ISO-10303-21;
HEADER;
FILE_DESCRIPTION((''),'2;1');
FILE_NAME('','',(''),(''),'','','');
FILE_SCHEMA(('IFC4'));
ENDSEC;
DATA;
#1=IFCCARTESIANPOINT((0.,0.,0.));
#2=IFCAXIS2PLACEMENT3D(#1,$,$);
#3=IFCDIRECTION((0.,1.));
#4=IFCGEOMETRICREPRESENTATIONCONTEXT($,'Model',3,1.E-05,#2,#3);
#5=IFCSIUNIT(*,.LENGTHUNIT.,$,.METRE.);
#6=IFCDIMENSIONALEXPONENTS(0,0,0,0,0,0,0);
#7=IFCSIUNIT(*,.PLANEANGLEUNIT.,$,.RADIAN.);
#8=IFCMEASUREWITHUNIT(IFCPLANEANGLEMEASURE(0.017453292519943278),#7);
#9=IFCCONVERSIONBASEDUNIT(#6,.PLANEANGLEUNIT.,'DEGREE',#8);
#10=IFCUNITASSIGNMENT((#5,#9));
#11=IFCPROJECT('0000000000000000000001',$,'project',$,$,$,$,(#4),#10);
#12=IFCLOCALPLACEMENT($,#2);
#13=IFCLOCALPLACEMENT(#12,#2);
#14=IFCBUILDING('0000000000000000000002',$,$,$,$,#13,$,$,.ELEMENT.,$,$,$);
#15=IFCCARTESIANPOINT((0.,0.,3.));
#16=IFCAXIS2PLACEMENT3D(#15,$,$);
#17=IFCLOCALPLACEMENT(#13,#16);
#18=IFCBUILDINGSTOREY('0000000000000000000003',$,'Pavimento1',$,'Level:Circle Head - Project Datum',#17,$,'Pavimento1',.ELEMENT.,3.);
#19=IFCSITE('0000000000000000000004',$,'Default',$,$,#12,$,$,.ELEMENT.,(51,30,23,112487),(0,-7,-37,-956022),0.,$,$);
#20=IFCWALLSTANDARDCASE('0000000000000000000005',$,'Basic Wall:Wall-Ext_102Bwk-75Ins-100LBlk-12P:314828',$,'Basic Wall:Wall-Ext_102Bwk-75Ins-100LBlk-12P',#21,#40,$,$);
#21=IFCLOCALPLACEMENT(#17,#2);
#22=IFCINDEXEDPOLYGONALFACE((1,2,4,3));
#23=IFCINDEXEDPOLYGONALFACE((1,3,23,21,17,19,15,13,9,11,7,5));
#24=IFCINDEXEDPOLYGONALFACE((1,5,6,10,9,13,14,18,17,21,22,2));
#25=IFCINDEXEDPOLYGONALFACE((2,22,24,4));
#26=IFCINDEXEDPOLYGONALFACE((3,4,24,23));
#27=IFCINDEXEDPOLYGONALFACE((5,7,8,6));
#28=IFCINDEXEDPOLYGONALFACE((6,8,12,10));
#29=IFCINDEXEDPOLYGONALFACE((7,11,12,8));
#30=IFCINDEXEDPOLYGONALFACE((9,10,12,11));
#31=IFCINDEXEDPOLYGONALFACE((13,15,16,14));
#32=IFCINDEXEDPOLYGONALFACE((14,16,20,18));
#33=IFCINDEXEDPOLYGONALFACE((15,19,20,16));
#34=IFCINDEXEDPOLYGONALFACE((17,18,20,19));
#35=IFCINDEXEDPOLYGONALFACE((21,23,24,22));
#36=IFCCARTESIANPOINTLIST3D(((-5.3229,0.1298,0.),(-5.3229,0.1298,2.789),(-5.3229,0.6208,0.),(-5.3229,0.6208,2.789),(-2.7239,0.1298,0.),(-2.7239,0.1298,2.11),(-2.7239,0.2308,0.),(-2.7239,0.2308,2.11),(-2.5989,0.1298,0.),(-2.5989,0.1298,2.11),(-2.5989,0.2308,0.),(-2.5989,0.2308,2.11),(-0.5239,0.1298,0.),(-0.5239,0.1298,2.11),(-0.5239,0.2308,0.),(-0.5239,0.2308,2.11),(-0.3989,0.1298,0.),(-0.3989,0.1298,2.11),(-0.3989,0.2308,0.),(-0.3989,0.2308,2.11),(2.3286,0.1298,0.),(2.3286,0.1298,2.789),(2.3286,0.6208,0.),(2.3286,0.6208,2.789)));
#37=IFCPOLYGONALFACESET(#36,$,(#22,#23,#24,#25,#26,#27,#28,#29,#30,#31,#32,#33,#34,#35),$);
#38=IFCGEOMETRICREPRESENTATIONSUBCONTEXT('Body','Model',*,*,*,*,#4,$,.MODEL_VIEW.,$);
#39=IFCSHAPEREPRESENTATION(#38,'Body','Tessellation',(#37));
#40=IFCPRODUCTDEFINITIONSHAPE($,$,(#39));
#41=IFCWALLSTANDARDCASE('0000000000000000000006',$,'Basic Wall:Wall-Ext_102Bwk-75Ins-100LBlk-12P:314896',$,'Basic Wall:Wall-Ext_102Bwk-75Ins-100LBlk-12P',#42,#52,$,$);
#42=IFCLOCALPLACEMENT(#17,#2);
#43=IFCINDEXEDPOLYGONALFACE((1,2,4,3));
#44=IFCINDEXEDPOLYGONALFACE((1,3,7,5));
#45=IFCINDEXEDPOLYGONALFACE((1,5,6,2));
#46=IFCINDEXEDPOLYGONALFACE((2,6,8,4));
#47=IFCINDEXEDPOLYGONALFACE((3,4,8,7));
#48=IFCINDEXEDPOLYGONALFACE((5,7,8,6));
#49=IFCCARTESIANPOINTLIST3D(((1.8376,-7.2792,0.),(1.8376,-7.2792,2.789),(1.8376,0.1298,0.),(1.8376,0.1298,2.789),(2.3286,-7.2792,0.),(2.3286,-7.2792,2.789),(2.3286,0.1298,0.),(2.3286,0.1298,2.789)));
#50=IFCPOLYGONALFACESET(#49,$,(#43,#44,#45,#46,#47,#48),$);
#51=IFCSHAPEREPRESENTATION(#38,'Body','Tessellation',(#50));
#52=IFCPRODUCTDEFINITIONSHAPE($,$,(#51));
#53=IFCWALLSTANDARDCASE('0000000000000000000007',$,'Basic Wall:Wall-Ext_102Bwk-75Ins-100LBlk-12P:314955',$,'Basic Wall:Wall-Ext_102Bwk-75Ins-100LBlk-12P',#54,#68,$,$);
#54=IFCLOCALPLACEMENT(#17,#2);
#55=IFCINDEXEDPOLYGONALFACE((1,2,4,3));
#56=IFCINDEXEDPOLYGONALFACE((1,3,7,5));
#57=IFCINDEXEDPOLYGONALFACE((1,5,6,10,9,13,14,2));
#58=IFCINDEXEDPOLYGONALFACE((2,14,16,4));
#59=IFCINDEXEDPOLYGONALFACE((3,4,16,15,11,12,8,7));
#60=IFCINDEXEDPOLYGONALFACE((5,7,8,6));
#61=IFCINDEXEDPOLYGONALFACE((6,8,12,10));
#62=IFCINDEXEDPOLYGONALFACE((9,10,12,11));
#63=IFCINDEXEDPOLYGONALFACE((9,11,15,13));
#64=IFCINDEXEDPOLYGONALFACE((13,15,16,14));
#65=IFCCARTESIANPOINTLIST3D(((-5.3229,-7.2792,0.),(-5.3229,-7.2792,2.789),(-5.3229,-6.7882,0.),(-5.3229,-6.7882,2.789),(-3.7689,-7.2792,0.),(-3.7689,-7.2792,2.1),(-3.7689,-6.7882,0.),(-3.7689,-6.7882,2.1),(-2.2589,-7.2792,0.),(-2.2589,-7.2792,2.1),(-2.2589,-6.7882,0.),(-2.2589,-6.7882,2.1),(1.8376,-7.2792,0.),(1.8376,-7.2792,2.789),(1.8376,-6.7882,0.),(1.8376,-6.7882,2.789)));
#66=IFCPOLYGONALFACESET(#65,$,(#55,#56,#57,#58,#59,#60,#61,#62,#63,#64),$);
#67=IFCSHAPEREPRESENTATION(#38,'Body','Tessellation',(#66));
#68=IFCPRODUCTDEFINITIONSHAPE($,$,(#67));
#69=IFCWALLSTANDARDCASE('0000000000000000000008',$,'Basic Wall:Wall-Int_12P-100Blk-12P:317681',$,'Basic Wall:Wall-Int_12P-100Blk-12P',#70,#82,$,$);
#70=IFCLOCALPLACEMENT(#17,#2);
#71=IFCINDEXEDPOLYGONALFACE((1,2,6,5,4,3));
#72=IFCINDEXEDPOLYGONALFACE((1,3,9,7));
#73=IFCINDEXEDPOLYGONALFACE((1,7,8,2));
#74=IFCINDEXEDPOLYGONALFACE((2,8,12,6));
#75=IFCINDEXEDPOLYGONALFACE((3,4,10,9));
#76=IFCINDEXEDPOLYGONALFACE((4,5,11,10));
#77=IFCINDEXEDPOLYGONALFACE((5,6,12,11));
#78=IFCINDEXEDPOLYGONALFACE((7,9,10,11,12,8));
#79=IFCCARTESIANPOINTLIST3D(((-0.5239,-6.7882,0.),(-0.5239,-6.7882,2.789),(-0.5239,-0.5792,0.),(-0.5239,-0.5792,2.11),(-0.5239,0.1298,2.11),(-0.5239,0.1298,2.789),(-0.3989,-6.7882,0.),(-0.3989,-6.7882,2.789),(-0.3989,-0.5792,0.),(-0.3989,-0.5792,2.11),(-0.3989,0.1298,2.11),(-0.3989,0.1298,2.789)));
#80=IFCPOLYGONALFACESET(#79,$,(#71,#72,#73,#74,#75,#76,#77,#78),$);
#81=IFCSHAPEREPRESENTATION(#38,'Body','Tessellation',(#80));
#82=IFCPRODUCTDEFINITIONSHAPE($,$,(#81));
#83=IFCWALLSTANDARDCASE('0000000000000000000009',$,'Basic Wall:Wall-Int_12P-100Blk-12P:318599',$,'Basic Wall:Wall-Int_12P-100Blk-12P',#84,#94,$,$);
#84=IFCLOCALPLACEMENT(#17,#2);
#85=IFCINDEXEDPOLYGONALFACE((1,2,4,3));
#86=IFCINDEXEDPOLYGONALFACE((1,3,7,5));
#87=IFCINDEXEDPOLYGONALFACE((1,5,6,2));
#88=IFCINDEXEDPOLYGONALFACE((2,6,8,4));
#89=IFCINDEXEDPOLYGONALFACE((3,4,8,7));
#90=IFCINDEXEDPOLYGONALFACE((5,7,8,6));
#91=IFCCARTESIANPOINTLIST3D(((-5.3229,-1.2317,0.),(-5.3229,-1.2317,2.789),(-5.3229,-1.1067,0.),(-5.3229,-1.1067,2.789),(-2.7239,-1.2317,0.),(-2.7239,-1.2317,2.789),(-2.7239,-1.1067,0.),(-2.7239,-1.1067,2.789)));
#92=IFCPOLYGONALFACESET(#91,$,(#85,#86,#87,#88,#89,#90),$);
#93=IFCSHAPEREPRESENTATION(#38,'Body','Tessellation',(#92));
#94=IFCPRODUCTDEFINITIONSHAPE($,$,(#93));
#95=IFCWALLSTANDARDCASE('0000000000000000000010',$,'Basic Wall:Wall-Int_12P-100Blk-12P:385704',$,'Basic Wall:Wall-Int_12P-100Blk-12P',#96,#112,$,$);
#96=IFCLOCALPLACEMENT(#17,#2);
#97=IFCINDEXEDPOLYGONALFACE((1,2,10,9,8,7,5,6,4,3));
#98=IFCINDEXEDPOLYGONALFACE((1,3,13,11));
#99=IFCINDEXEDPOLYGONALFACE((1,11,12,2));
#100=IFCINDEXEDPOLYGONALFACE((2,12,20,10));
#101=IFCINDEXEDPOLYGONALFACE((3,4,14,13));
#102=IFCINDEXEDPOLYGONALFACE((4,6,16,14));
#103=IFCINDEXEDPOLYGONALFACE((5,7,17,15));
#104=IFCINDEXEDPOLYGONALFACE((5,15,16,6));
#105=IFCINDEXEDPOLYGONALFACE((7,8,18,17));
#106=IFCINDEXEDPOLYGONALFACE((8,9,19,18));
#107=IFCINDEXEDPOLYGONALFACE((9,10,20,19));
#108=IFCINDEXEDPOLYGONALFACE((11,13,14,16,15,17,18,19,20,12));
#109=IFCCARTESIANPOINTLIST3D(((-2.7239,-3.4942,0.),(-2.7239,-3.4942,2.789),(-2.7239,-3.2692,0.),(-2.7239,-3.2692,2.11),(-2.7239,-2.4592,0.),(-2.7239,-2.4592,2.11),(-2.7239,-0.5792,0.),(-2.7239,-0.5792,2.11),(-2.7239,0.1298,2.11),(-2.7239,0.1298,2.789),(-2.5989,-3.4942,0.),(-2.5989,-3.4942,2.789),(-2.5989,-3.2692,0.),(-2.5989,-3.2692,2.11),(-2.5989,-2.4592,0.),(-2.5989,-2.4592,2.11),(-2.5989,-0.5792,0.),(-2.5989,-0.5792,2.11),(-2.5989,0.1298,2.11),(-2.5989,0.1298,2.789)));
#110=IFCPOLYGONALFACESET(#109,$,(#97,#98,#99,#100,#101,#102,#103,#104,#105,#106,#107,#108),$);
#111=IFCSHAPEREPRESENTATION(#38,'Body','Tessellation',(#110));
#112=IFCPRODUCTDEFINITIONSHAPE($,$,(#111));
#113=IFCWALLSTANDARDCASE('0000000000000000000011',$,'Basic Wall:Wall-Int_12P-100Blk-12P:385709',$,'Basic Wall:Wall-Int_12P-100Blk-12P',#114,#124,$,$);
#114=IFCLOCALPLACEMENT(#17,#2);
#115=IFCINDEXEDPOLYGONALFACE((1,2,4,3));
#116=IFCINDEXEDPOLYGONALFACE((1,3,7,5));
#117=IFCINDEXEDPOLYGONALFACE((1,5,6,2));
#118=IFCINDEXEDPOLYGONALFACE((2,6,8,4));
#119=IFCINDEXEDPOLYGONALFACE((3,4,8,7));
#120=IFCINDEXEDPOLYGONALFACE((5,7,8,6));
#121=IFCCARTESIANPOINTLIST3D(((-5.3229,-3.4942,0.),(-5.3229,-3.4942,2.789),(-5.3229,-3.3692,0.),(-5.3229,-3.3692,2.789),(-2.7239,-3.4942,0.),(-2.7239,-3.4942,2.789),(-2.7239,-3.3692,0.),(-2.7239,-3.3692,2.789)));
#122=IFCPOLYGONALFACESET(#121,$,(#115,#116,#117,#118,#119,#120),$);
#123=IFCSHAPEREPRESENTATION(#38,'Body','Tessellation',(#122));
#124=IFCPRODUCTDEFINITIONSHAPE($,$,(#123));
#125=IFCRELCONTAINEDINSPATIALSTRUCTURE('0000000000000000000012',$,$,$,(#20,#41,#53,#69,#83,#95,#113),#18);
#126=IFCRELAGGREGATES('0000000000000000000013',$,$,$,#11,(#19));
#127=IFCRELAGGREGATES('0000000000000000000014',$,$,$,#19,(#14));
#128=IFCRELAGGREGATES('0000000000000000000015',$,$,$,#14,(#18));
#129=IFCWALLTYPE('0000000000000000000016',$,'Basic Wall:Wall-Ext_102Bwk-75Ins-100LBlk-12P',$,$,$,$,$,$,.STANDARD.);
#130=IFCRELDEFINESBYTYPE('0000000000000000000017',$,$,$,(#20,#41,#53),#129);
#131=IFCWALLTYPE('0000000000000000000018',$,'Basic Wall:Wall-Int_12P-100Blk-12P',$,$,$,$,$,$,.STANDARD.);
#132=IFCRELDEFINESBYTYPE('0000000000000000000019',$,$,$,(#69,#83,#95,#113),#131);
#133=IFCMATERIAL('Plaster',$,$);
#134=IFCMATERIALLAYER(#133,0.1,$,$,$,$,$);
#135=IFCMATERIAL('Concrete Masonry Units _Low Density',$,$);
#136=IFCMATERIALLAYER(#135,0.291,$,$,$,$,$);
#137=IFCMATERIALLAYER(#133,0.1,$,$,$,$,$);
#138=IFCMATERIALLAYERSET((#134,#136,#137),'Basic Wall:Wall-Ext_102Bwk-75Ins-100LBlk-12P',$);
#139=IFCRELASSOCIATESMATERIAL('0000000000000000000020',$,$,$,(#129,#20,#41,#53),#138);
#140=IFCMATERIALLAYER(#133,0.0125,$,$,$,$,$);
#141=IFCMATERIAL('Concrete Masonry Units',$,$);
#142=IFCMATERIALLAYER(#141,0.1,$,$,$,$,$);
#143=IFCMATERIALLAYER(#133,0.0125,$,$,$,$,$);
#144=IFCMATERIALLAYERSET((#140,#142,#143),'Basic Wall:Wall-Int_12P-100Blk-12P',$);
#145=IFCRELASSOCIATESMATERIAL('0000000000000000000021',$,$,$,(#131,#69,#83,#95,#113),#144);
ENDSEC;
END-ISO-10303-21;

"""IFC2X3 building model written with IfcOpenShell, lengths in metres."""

from ifc_helpers import new_model, entity, si_unit, converted_unit, direction, frame, frame_2d, origin, place, context, subcontext, project, spatial, polyline, rectangle, extrude, clip, bounded_halfspace, material, layer, layer_set, layer_usage, type_object, element, save


model = new_model("IFC2X3")

# Units and contexts
model_context = context("Model", 3, precision=1e-05, world=origin(), true_north=direction((0.0, 1.0)))
body_context = subcontext(model_context, "Body", "Model", "MODEL_VIEW")
ifc_project = project(units=[si_unit("LENGTHUNIT", "METRE"), converted_unit("PLANEANGLEUNIT", "DEGREE", entity("IfcPlaneAngleMeasure", 0.017453292519943278), si_unit("PLANEANGLEUNIT", "RADIAN"), dimensions=[0, 0, 0, 0, 0, 0, 0])], contexts=[model_context])

# Site, building, storey
site_placement = place(None, origin())
site = spatial("IfcSite", under=ifc_project, at=site_placement, Name="Default", CompositionType="ELEMENT", RefLatitude=(51, 30, 23, 112487), RefLongitude=(0, -7, -37, -956022), RefElevation=0.0)
building_placement = place(site_placement, origin())
building = spatial("IfcBuilding", under=site, at=building_placement, CompositionType="ELEMENT")
storey_placement = place(building_placement, frame((0.0, 0.0, 3.0)))
storey = spatial("IfcBuildingStorey", under=building, at=storey_placement, Name="Pavimento1", ObjectType="Level:Circle Head - Project Datum", LongName="Pavimento1", CompositionType="ELEMENT", Elevation=3.0)

# Wall, openings
ifc_material_1 = material(Name="Plaster")
ifc_layer_1 = layer(ifc_material_1, 0.1)
ifc_material_2 = material(Name="Concrete Masonry Units _Low Density")
ifc_layer_2 = layer(ifc_material_2, 0.291)
ifc_layer_3 = layer(ifc_material_1, 0.1)
ifc_layer_set_1 = layer_set([ifc_layer_1, ifc_layer_2, ifc_layer_3], Name="Basic Wall:Wall-Ext_102Bwk-75Ins-100LBlk-12P")
ifc_layer_usage_1 = layer_usage(ifc_layer_set_1, "AXIS2", "NEGATIVE", 0.2455)
wall_type_1 = type_object("IfcWallType", Name="Basic Wall:Wall-Ext_102Bwk-75Ins-100LBlk-12P", PredefinedType="STANDARD", material=ifc_layer_set_1)
wall_1_placement = place(storey_placement, frame((-5.3229, 0.3753, 0.0)))
wall_1 = element("IfcWallStandardCase", 1, at=wall_1_placement, inside=storey, type_object=wall_type_1, material=ifc_layer_usage_1, Name="Basic Wall:Wall-Ext_102Bwk-75Ins-100LBlk-12P:314828", ObjectType="Basic Wall:Wall-Ext_102Bwk-75Ins-100LBlk-12P", context=body_context, shape_type="Clipping", body=[
    clip(extrude(rectangle(XDim=7.6515, YDim=0.491, at=frame_2d((3.8258, 0.0), x_axis=(-1.0, 0.0))), origin(), (0.0, 0.0, 1.0), 2.789), bounded_halfspace(frame((0.0, -0.2455, 2.789), z_axis=(0.0, 0.0, -1.0), x_axis=(0.0, -1.0, 0.0)), True, frame((0.0, -0.2455, 2.789)), polyline([(0.0, 0.0), (2.599, 0.0), (2.724, 0.0), (4.799, 0.0), (4.924, 0.0), (7.1605, 0.0), (7.6515, 0.0), (7.6515, 0.491), (0.0, 0.491), (0.0, 0.0)]))),
])
opening_1_placement = place(wall_1_placement, origin())
element("IfcOpeningElement", 2, at=opening_1_placement, cuts=wall_1, ObjectType="Opening", context=body_context, shape_type="SweptSolid", body=[
    extrude(rectangle(XDim=2.11, YDim=0.125, at=frame_2d((0.0, 0.0), x_axis=(0.0, 1.0))), frame((2.6615, -0.9545, 1.055), z_axis=(0.0, 1.0, 0.0), x_axis=(-1.0, 0.0, 0.0)), (0.0, 0.0, 1.0), 0.81),
])
opening_2_placement = place(wall_1_placement, origin())
element("IfcOpeningElement", 3, at=opening_2_placement, cuts=wall_1, ObjectType="Opening", context=body_context, shape_type="SweptSolid", body=[
    extrude(rectangle(XDim=2.11, YDim=0.125, at=frame_2d((0.0, 0.0), x_axis=(0.0, 1.0))), frame((4.8615, -0.9545, 1.055), z_axis=(0.0, 1.0, 0.0), x_axis=(-1.0, 0.0, 0.0)), (0.0, 0.0, 1.0), 0.81),
])

# Wall
wall_2_placement = place(storey_placement, frame((2.0831, 0.1298, 0.0), z_axis=(0.0, 0.0, 1.0), x_axis=(0.0, -1.0, 0.0)))
element("IfcWallStandardCase", 4, at=wall_2_placement, inside=storey, type_object=wall_type_1, material=ifc_layer_usage_1, Name="Basic Wall:Wall-Ext_102Bwk-75Ins-100LBlk-12P:314896", ObjectType="Basic Wall:Wall-Ext_102Bwk-75Ins-100LBlk-12P", context=body_context, shape_type="Clipping", body=[
    clip(extrude(rectangle(XDim=7.409, YDim=0.491, at=frame_2d((3.7045, 0.0), x_axis=(-1.0, 0.0))), origin(), (0.0, 0.0, 1.0), 2.789), bounded_halfspace(frame((0.0, -0.2455, 2.789), z_axis=(0.0, 0.0, -1.0), x_axis=(1.0, 0.0, 0.0)), True, frame((0.0, -0.2455, 2.789)), polyline([(0.0, 0.0), (1.7625, 0.0), (6.0125, 0.0), (6.918, 0.0), (7.409, 0.0), (7.409, 0.491), (0.0, 0.491), (0.0, 0.0)]))),
])

# Walls, openings
wall_3_placement = place(storey_placement, frame((1.8376, -7.0337, 0.0), z_axis=(0.0, 0.0, 1.0), x_axis=(-1.0, 0.0, 0.0)))
wall_3 = element("IfcWallStandardCase", 5, at=wall_3_placement, inside=storey, type_object=wall_type_1, material=ifc_layer_usage_1, Name="Basic Wall:Wall-Ext_102Bwk-75Ins-100LBlk-12P:314955", ObjectType="Basic Wall:Wall-Ext_102Bwk-75Ins-100LBlk-12P", context=body_context, shape_type="Clipping", body=[
    clip(extrude(rectangle(XDim=7.1605, YDim=0.491, at=frame_2d((3.5803, 0.0), x_axis=(-1.0, 0.0))), origin(), (0.0, 0.0, 1.0), 2.789), bounded_halfspace(frame((0.0, 0.2455, 2.789), z_axis=(0.0, 0.0, -1.0), x_axis=(0.0, 1.0, 0.0)), True, frame((0.0, 0.2455, 2.789)), polyline([(0.0, 0.0), (0.0, -0.491), (2.2365, -0.491), (2.3615, -0.491), (7.1605, -0.491), (7.1605, 0.0), (6.3515, 0.0), (3.3515, 0.0), (0.0, 0.0)]))),
])
opening_3_placement = place(wall_3_placement, frame((1.8376, -7.0337, 0.0), z_axis=(0.0, 0.0, 1.0), x_axis=(-1.0, 0.0, 0.0)))
element("IfcOpeningElement", 6, at=opening_3_placement, cuts=wall_3, ObjectType="Opening", context=body_context, shape_type="SweptSolid", body=[
    extrude(rectangle(XDim=2.1, YDim=1.51, at=frame_2d((0.0, 0.0), x_axis=(0.0, 1.0))), frame((-3.0139, -6.4882, 1.05), z_axis=(0.0, -1.0, 0.0), x_axis=(-1.0, 0.0, 0.0)), (0.0, 0.0, 1.0), 1.091),
])
ifc_layer_4 = layer(ifc_material_1, 0.0125)
ifc_material_3 = material(Name="Concrete Masonry Units")
ifc_layer_5 = layer(ifc_material_3, 0.1)
ifc_layer_6 = layer(ifc_material_1, 0.0125)
ifc_layer_set_2 = layer_set([ifc_layer_4, ifc_layer_5, ifc_layer_6], Name="Basic Wall:Wall-Int_12P-100Blk-12P")
ifc_layer_usage_2 = layer_usage(ifc_layer_set_2, "AXIS2", "NEGATIVE", 0.0625)
wall_type_2 = type_object("IfcWallType", Name="Basic Wall:Wall-Int_12P-100Blk-12P", PredefinedType="STANDARD", material=ifc_layer_set_2)
wall_4_placement = place(storey_placement, frame((-0.4614, 0.1298, 0.0), z_axis=(0.0, 0.0, 1.0), x_axis=(0.0, -1.0, 0.0)))
wall_4 = element("IfcWallStandardCase", 7, at=wall_4_placement, inside=storey, type_object=wall_type_2, material=ifc_layer_usage_2, Name="Basic Wall:Wall-Int_12P-100Blk-12P:317681", ObjectType="Basic Wall:Wall-Int_12P-100Blk-12P", context=body_context, shape_type="Clipping", body=[
    clip(extrude(rectangle(XDim=6.918, YDim=0.125, at=frame_2d((3.459, 0.0), x_axis=(-1.0, 0.0))), origin(), (0.0, 0.0, 1.0), 2.789), bounded_halfspace(frame((0.0, -0.0625, 2.789), z_axis=(0.0, 0.0, -1.0), x_axis=(1.0, 0.0, 0.0)), True, frame((0.0, -0.0625, 2.789)), polyline([(0.0, 0.0), (6.918, 0.0), (6.918, 0.125), (0.0, 0.125), (0.0, 0.0)]))),
])
opening_4_placement = place(wall_4_placement, frame((0.709, 0.0625, 0.0)))
element("IfcOpeningElement", 8, at=opening_4_placement, cuts=wall_4, ObjectType="Opening", context=body_context, shape_type="SweptSolid", body=[
    extrude(rectangle(XDim=2.11, YDim=0.81, at=frame_2d((1.055, 0.405), x_axis=(1.0, 0.0))), frame((0.0, 0.0, 0.0), z_axis=(0.0, -1.0, 0.0), x_axis=(0.0, 0.0, 1.0)), (0.0, 0.0, 1.0), 0.125),
])

# Wall
wall_5_placement = place(storey_placement, frame((-2.7239, -1.1692, 0.0), z_axis=(0.0, 0.0, 1.0), x_axis=(-1.0, 0.0, 0.0)))
element("IfcWallStandardCase", 9, at=wall_5_placement, inside=storey, type_object=wall_type_2, material=ifc_layer_usage_2, Name="Basic Wall:Wall-Int_12P-100Blk-12P:318599", ObjectType="Basic Wall:Wall-Int_12P-100Blk-12P", context=body_context, shape_type="Clipping", body=[
    clip(extrude(rectangle(XDim=2.599, YDim=0.125, at=frame_2d((1.2995, 0.0), x_axis=(-1.0, 0.0))), origin(), (0.0, 0.0, 1.0), 2.789), bounded_halfspace(frame((0.0, -0.0625, 2.789), z_axis=(0.0, 0.0, -1.0), x_axis=(0.0, 1.0, 0.0)), True, frame((0.0, -0.0625, 2.789)), polyline([(0.0, 0.0), (2.599, 0.0), (2.599, 0.125), (0.0, 0.125), (0.0, 0.0)]))),
])

# Wall, openings
wall_6_placement = place(storey_placement, frame((-2.6614, 0.1298, 0.0), z_axis=(0.0, 0.0, 1.0), x_axis=(0.0, -1.0, 0.0)))
wall_6 = element("IfcWallStandardCase", 10, at=wall_6_placement, inside=storey, type_object=wall_type_2, material=ifc_layer_usage_2, Name="Basic Wall:Wall-Int_12P-100Blk-12P:385704", ObjectType="Basic Wall:Wall-Int_12P-100Blk-12P", context=body_context, shape_type="SweptSolid", body=[
    extrude(rectangle(XDim=3.624, YDim=0.125, at=frame_2d((1.812, 0.0), x_axis=(-1.0, 0.0))), origin(), (0.0, 0.0, 1.0), 2.789),
])
opening_5_placement = place(wall_6_placement, frame((0.709, 0.0625, 0.0)))
element("IfcOpeningElement", 11, at=opening_5_placement, cuts=wall_6, ObjectType="Opening", context=body_context, shape_type="SweptSolid", body=[
    extrude(rectangle(XDim=2.11, YDim=0.81, at=frame_2d((1.055, 0.405), x_axis=(1.0, 0.0))), frame((0.0, 0.0, 0.0), z_axis=(0.0, -1.0, 0.0), x_axis=(0.0, 0.0, 1.0)), (0.0, 0.0, 1.0), 0.125),
])
opening_6_placement = place(wall_6_placement, frame((3.399, 0.0625, 0.0)))
element("IfcOpeningElement", 12, at=opening_6_placement, cuts=wall_6, ObjectType="Opening", context=body_context, shape_type="SweptSolid", body=[
    extrude(rectangle(XDim=2.11, YDim=0.81, at=frame_2d((1.055, 0.405), x_axis=(1.0, 0.0))), frame((0.0, 0.0, 0.0), z_axis=(0.0, -1.0, 0.0), x_axis=(0.0, 0.0, 1.0)), (0.0, 0.0, 1.0), 0.125),
])

# Wall
wall_7_placement = place(storey_placement, frame((-2.7239, -3.4317, 0.0), z_axis=(0.0, 0.0, 1.0), x_axis=(-1.0, 0.0, 0.0)))
element("IfcWallStandardCase", 13, at=wall_7_placement, inside=storey, type_object=wall_type_2, material=ifc_layer_usage_2, Name="Basic Wall:Wall-Int_12P-100Blk-12P:385709", ObjectType="Basic Wall:Wall-Int_12P-100Blk-12P", context=body_context, shape_type="SweptSolid", body=[
    extrude(rectangle(XDim=2.599, YDim=0.125, at=frame_2d((1.2995, 0.0), x_axis=(-1.0, 0.0))), origin(), (0.0, 0.0, 1.0), 2.789),
])

save(model, "model.ifc")
